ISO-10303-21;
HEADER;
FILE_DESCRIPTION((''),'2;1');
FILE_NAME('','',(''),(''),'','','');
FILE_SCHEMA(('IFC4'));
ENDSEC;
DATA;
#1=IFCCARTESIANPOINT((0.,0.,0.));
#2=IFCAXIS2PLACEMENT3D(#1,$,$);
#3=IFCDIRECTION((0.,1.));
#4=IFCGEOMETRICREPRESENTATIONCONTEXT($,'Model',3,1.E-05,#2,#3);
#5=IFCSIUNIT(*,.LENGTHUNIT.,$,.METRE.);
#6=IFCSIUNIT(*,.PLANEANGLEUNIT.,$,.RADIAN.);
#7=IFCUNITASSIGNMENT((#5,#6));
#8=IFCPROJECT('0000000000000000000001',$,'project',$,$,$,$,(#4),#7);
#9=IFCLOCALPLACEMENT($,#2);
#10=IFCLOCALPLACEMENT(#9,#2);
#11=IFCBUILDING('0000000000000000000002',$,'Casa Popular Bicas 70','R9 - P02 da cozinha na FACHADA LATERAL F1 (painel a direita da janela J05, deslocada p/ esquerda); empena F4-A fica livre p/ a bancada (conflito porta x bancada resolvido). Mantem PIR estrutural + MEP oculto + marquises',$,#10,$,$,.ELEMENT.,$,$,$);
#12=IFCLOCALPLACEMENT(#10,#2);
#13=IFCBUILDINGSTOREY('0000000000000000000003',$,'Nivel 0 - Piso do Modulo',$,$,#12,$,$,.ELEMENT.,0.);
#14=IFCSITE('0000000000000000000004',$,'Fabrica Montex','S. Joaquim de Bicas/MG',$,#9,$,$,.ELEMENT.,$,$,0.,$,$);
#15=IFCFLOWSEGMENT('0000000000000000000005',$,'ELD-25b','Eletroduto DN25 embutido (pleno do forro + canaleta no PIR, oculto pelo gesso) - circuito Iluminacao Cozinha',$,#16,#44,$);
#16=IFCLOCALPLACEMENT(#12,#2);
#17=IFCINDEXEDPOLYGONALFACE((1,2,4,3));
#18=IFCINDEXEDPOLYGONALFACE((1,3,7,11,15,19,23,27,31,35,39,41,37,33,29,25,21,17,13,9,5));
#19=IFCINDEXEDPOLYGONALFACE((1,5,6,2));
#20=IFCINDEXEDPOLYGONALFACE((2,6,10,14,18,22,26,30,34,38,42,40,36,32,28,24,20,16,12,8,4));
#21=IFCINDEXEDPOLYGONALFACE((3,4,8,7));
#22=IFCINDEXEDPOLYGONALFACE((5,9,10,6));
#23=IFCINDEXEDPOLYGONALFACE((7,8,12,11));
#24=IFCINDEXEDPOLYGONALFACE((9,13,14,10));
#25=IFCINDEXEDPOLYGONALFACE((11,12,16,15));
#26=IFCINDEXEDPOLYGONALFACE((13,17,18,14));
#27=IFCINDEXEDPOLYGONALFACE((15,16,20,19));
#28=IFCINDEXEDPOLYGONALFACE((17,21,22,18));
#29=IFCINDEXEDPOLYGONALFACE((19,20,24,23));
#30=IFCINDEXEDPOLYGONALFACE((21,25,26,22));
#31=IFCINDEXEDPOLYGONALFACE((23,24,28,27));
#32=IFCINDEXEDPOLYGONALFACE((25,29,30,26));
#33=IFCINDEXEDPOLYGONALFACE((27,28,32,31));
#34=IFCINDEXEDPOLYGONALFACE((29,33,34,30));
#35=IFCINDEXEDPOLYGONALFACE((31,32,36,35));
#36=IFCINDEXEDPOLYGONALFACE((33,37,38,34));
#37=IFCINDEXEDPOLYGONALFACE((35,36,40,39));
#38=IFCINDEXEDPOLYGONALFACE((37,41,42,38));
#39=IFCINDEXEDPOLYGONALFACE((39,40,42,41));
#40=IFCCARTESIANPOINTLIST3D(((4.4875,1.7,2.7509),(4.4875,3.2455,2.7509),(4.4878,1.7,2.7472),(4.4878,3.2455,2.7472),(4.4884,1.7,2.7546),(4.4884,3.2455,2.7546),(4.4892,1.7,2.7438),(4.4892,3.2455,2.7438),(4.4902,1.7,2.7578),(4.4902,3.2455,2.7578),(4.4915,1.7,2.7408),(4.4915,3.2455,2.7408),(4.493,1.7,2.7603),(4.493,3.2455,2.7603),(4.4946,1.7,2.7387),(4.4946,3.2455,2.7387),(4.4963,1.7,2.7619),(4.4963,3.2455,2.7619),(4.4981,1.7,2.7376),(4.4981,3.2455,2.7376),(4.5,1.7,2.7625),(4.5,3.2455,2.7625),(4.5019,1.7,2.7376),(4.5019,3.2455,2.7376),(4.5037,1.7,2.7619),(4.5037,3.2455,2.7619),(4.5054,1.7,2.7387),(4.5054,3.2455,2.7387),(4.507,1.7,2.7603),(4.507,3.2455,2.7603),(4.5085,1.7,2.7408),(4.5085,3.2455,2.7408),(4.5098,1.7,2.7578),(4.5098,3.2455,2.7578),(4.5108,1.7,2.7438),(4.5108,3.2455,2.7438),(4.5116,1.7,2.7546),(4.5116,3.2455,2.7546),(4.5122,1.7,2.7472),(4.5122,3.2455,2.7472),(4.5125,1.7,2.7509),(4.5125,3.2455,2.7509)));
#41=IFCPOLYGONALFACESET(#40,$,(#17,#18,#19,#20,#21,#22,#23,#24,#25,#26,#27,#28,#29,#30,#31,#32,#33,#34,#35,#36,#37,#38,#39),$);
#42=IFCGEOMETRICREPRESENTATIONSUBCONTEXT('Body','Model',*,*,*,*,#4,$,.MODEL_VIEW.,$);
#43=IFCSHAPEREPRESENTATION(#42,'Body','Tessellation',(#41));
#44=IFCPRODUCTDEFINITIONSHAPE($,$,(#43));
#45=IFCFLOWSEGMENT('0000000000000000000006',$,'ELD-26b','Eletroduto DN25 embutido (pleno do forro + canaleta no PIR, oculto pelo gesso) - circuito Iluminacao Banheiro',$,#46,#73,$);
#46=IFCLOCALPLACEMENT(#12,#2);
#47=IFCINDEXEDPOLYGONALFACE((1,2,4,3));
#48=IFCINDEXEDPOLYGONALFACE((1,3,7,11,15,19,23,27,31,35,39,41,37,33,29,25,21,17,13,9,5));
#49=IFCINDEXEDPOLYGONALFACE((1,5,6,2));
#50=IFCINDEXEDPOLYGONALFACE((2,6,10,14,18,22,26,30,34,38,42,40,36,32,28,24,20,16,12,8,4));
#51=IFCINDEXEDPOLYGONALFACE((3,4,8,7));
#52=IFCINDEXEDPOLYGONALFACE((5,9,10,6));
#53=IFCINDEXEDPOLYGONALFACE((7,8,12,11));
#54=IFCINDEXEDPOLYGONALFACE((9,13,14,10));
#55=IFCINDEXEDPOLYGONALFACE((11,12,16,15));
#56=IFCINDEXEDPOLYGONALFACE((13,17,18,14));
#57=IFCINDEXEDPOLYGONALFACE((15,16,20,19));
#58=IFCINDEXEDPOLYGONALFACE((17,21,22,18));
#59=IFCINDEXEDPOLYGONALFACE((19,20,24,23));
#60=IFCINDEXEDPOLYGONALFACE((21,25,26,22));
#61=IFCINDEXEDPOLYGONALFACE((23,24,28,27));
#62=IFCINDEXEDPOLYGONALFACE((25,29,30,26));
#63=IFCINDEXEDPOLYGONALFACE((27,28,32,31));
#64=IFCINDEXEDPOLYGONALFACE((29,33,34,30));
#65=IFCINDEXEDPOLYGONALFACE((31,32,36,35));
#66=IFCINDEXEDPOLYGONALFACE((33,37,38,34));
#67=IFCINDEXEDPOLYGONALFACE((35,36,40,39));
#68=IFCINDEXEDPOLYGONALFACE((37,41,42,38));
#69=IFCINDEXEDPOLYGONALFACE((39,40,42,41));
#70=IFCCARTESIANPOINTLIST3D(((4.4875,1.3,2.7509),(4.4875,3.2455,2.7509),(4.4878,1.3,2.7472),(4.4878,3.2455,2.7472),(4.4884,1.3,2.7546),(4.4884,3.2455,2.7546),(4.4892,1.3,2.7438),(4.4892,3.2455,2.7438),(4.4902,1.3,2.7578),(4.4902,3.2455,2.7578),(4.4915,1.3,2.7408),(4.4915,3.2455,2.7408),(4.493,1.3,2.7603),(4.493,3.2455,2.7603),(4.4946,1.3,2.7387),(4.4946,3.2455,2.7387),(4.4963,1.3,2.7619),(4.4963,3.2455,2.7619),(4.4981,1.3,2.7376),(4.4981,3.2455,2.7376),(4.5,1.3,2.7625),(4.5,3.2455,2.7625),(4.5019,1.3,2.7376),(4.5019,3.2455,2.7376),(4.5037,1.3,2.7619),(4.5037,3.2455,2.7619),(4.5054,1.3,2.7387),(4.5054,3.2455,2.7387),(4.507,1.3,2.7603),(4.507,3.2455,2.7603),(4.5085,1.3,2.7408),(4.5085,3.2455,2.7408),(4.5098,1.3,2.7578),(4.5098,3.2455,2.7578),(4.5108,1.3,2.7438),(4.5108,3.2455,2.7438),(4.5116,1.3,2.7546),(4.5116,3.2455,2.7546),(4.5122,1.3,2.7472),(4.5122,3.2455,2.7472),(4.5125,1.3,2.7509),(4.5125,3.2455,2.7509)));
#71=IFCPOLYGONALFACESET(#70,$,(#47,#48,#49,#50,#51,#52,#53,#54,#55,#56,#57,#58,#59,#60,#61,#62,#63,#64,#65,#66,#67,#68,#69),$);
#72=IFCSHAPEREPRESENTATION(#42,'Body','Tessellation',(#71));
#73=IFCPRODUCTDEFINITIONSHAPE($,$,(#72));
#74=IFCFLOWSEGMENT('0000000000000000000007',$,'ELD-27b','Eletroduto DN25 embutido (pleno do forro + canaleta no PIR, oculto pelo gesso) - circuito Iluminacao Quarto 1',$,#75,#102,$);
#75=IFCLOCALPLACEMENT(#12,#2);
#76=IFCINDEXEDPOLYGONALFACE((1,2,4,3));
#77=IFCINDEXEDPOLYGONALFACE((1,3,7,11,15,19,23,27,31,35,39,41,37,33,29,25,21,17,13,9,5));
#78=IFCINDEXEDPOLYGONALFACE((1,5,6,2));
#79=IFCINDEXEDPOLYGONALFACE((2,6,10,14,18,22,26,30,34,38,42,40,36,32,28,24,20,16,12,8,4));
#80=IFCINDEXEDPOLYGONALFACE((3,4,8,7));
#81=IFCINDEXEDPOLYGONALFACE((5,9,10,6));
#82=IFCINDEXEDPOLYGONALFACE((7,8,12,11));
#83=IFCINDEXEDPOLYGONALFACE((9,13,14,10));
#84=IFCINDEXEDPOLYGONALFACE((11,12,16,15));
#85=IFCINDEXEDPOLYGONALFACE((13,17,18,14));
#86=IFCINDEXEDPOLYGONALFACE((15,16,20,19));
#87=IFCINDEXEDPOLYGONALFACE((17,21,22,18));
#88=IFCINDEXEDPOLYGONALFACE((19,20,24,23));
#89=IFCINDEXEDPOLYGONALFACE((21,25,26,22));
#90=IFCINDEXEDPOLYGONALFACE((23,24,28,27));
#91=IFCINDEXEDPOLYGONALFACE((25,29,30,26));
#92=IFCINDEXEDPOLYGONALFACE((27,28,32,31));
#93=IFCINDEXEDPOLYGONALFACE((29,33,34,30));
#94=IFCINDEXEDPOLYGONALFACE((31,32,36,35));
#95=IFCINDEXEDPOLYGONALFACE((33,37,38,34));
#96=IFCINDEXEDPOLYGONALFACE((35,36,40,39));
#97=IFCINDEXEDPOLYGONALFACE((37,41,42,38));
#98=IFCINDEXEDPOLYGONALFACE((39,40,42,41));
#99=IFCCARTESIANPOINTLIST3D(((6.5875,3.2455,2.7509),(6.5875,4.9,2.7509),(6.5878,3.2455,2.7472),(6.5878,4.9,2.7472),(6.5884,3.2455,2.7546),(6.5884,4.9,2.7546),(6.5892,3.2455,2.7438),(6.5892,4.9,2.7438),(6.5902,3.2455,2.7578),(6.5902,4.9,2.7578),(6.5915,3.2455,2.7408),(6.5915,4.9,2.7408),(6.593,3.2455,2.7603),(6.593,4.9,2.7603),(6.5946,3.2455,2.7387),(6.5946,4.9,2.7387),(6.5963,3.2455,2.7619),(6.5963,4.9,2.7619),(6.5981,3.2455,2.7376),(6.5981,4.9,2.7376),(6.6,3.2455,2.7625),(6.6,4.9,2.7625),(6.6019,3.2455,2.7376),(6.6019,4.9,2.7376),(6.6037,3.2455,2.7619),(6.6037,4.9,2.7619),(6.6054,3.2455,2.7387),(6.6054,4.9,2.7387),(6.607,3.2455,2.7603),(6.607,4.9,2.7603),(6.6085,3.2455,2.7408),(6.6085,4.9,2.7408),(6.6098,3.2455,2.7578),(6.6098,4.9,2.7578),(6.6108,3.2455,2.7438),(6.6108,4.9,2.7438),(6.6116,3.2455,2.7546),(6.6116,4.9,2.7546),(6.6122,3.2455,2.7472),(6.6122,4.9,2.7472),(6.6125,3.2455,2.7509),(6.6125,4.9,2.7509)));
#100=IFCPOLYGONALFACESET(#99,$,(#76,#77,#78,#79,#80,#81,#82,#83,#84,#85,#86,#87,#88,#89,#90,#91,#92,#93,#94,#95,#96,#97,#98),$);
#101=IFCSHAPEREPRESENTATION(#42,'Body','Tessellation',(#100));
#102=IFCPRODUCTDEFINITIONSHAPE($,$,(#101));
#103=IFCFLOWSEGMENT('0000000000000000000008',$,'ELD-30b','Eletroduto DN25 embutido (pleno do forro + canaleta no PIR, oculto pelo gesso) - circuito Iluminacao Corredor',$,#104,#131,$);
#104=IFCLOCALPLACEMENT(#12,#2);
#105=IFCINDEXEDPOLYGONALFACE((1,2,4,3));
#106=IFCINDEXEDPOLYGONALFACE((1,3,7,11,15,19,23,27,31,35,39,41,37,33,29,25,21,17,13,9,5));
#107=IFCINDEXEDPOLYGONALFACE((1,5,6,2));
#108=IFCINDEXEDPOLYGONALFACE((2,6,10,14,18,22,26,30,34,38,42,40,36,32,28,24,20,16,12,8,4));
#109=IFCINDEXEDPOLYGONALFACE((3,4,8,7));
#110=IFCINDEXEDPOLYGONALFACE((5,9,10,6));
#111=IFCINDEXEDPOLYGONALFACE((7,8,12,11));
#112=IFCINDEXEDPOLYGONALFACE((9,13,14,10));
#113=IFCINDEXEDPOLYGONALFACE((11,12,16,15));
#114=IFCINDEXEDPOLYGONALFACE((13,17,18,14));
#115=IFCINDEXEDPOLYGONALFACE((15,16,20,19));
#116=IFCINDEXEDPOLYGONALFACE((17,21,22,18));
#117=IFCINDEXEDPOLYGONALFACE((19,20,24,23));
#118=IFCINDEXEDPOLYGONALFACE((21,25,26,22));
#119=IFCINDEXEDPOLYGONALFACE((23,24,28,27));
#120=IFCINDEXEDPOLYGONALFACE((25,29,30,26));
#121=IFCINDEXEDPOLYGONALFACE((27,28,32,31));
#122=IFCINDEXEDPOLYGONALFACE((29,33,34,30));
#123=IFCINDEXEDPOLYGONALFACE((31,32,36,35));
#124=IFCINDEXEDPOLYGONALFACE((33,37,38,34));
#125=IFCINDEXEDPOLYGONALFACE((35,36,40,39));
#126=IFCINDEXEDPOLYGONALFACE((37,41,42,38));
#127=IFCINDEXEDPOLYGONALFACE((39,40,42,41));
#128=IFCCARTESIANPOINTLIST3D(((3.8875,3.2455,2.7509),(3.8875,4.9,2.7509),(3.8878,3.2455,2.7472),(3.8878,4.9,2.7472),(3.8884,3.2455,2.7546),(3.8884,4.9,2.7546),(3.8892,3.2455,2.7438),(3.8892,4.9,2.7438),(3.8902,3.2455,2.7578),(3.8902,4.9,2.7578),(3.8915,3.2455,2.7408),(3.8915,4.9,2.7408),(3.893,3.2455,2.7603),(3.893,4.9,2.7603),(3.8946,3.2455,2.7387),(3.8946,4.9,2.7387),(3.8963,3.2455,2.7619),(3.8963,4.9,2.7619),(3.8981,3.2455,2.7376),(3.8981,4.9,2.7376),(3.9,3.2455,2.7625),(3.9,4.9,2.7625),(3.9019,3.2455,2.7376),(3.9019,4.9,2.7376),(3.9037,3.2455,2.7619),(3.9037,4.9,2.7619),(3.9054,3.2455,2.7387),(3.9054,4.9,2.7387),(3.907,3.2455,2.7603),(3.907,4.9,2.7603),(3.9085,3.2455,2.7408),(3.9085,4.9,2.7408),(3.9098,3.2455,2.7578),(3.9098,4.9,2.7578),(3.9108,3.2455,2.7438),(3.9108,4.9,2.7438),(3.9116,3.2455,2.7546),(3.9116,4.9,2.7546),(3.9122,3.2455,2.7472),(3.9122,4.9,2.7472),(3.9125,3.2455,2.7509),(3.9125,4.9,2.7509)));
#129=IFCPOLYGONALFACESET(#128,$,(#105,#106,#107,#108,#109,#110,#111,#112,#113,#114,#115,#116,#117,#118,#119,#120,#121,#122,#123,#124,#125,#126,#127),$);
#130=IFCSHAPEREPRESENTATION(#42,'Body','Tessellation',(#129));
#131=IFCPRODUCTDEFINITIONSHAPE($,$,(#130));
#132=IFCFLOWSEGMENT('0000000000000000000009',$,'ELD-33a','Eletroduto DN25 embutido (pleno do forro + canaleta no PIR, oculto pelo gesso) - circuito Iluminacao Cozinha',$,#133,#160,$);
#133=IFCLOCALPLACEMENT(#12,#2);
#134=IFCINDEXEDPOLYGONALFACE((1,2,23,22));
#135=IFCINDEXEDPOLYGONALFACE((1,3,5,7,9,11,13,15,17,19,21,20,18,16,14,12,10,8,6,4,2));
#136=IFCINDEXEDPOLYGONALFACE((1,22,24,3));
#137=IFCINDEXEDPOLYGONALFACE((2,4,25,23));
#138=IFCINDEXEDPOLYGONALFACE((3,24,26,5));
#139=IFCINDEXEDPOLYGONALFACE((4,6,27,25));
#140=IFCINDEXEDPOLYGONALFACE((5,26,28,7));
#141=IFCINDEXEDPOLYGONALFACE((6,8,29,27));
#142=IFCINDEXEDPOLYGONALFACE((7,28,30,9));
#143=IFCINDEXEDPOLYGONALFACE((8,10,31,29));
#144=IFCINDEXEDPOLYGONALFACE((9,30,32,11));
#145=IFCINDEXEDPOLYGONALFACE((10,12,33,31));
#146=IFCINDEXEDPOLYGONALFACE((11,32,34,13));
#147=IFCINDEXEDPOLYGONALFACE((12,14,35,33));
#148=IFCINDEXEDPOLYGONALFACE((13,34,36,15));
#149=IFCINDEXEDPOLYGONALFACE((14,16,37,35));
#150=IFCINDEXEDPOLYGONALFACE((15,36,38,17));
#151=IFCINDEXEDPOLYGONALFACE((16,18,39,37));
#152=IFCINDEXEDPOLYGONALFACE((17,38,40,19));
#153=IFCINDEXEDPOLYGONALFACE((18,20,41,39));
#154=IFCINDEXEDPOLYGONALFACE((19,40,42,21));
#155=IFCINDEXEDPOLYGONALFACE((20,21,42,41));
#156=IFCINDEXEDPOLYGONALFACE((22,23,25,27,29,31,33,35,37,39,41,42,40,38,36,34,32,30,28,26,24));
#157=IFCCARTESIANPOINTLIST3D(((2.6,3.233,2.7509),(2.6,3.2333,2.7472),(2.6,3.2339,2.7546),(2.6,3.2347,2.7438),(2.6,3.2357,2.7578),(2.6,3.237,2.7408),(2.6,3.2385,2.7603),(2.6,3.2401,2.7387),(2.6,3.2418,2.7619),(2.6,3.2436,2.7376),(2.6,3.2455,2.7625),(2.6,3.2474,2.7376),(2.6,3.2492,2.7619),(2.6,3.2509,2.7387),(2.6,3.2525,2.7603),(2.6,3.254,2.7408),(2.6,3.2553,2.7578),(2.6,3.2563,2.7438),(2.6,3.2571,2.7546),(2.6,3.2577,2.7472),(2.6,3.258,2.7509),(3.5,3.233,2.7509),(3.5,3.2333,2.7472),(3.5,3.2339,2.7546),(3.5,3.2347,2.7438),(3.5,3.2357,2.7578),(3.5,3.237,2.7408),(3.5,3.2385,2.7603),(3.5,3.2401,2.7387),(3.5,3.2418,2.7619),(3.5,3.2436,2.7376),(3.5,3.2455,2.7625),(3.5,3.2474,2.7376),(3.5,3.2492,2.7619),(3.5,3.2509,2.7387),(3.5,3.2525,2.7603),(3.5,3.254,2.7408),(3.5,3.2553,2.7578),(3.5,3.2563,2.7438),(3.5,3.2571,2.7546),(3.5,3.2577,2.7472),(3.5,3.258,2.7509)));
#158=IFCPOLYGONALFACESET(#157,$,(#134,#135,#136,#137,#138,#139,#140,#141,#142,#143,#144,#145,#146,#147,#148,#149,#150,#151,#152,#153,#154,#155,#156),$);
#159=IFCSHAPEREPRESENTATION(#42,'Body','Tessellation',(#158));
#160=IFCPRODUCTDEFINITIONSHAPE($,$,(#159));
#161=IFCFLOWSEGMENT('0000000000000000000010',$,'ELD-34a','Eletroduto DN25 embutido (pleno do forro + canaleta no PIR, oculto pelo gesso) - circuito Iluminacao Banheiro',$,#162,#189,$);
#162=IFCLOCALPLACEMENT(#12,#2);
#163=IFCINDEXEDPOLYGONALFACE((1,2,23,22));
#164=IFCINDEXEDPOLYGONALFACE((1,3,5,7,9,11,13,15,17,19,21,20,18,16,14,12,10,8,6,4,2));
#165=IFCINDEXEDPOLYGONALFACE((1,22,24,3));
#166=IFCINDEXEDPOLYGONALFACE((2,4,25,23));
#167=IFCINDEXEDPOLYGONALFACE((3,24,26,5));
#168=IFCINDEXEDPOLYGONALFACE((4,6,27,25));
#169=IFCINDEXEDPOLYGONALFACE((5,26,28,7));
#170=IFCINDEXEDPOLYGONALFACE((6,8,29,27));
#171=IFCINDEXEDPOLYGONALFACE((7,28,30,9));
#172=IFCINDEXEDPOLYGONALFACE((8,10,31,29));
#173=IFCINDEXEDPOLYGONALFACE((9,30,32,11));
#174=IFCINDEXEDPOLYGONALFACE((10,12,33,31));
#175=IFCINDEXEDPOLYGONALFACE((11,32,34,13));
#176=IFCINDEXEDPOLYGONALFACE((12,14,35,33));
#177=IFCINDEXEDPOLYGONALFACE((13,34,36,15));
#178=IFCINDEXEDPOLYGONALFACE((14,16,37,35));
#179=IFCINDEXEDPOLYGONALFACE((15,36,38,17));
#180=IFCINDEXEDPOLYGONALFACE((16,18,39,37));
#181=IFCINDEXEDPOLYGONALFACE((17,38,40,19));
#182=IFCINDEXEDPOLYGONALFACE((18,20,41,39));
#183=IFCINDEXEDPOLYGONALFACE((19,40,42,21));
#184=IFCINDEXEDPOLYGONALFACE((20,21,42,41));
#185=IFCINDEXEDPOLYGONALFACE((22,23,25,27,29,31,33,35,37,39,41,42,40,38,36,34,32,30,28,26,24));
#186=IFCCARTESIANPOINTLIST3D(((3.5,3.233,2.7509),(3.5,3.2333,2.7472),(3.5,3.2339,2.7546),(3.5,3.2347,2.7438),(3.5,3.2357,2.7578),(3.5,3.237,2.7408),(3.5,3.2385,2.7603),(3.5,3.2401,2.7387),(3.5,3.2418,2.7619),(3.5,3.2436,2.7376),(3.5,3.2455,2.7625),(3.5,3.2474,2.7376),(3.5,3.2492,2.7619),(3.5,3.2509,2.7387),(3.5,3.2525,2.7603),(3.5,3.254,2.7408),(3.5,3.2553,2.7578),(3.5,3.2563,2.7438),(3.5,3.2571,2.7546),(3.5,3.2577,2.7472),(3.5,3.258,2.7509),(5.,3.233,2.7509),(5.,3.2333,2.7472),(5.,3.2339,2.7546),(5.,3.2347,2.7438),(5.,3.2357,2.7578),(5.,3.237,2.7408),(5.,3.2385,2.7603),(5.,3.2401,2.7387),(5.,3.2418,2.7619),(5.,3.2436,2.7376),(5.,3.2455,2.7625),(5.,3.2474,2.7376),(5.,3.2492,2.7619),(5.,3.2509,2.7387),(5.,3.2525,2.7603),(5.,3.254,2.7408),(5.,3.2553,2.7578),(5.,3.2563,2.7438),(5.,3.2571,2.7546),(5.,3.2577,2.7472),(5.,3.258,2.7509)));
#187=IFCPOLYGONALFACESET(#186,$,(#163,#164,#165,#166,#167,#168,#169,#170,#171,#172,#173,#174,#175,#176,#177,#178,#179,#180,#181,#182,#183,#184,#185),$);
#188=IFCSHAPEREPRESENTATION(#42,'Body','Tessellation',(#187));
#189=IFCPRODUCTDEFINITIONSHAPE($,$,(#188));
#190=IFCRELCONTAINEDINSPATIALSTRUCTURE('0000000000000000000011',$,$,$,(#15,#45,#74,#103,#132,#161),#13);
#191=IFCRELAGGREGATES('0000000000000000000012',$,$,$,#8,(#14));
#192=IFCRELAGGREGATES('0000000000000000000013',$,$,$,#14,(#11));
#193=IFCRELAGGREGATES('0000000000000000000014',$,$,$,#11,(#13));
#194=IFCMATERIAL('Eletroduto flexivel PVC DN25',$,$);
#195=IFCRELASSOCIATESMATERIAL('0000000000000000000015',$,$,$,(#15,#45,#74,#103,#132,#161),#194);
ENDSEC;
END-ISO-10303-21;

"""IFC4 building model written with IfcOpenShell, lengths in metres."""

from ifc_helpers import new_model, si_unit, direction, frame, origin, origin_2d, place, context, subcontext, project, spatial, circle, extrude, material, element, save


model = new_model("IFC4")

# Units and contexts
model_context = context("Model", 3, precision=1e-05, world=origin(), true_north=direction((0.0, 1.0)))
body_context = subcontext(model_context, "Body", "Model", "MODEL_VIEW")
ifc_project = project(units=[si_unit("LENGTHUNIT", "METRE"), si_unit("PLANEANGLEUNIT", "RADIAN")], contexts=[model_context])

# Site, building, storey
site_placement = place(None, origin())
site = spatial("IfcSite", under=ifc_project, at=site_placement, Name="Fabrica Montex", Description="S. Joaquim de Bicas/MG", CompositionType="ELEMENT", RefElevation=0.0)
building_placement = place(site_placement, origin())
building = spatial("IfcBuilding", under=site, at=building_placement, Name="Casa Popular Bicas 70", Description="R9 - P02 da cozinha na FACHADA LATERAL F1 (painel a direita da janela J05, deslocada p/ esquerda); empena F4-A fica livre p/ a bancada (conflito porta x bancada resolvido). Mantem PIR estrutural + MEP oculto + marquises", CompositionType="ELEMENT")
storey_placement = place(building_placement, origin())
storey = spatial("IfcBuildingStorey", under=building, at=storey_placement, Name="Nivel 0 - Piso do Modulo", CompositionType="ELEMENT", Elevation=0.0)

# Flow segments
ifc_material_1 = material(Name="Eletroduto flexivel PVC DN25")
flow_segment_1_placement = place(storey_placement, frame((4.5, 3.2455, 2.75), z_axis=(0.0, -1.0, 0.0), x_axis=(0.0, 0.0, 1.0)))
element("IfcFlowSegment", 1, at=flow_segment_1_placement, inside=storey, material=ifc_material_1, Name="ELD-25b", Description="Eletroduto DN25 embutido (pleno do forro + canaleta no PIR, oculto pelo gesso) - circuito Iluminacao Cozinha", context=body_context, shape_type="SweptSolid", body=[
    extrude(circle(Radius=0.0125, at=origin_2d()), origin(), (0.0, 0.0, 1.0), 1.5455),
])
flow_segment_2_placement = place(storey_placement, frame((4.5, 3.2455, 2.75), z_axis=(0.0, -1.0, 0.0), x_axis=(0.0, 0.0, 1.0)))
element("IfcFlowSegment", 2, at=flow_segment_2_placement, inside=storey, material=ifc_material_1, Name="ELD-26b", Description="Eletroduto DN25 embutido (pleno do forro + canaleta no PIR, oculto pelo gesso) - circuito Iluminacao Banheiro", context=body_context, shape_type="SweptSolid", body=[
    extrude(circle(Radius=0.0125, at=origin_2d()), origin(), (0.0, 0.0, 1.0), 1.9455),
])
for number, where, z_axis, x_axis, name, description in (
    (3, (6.6, 3.2455, 2.75), (0.0, 1.0, 0.0), (0.0, 0.0, 1.0), "ELD-27b", "Eletroduto DN25 embutido (pleno do forro + canaleta no PIR, oculto pelo gesso) - circuito Iluminacao Quarto 1"),
    (4, (3.9, 3.2455, 2.75), (0.0, 1.0, 0.0), (0.0, 0.0, 1.0), "ELD-30b", "Eletroduto DN25 embutido (pleno do forro + canaleta no PIR, oculto pelo gesso) - circuito Iluminacao Corredor"),
):
    element("IfcFlowSegment", number, at=place(storey_placement, frame(where, z_axis=z_axis, x_axis=x_axis)), inside=storey, material=ifc_material_1, Name=name, Description=description, context=body_context, shape_type="SweptSolid", body=[
        extrude(circle(Radius=0.0125, at=origin_2d()), origin(), (0.0, 0.0, 1.0), 1.6545),
    ])
flow_segment_3_placement = place(storey_placement, frame((3.5, 3.2455, 2.75), z_axis=(-1.0, 0.0, 0.0), x_axis=(0.0, 0.0, 1.0)))
element("IfcFlowSegment", 5, at=flow_segment_3_placement, inside=storey, material=ifc_material_1, Name="ELD-33a", Description="Eletroduto DN25 embutido (pleno do forro + canaleta no PIR, oculto pelo gesso) - circuito Iluminacao Cozinha", context=body_context, shape_type="SweptSolid", body=[
    extrude(circle(Radius=0.0125, at=origin_2d()), origin(), (0.0, 0.0, 1.0), 0.9),
])
flow_segment_4_placement = place(storey_placement, frame((3.5, 3.2455, 2.75), z_axis=(1.0, 0.0, 0.0), x_axis=(0.0, 0.0, 1.0)))
element("IfcFlowSegment", 6, at=flow_segment_4_placement, inside=storey, material=ifc_material_1, Name="ELD-34a", Description="Eletroduto DN25 embutido (pleno do forro + canaleta no PIR, oculto pelo gesso) - circuito Iluminacao Banheiro", context=body_context, shape_type="SweptSolid", body=[
    extrude(circle(Radius=0.0125, at=origin_2d()), origin(), (0.0, 0.0, 1.0), 1.5),
])

save(model, "model.ifc")
